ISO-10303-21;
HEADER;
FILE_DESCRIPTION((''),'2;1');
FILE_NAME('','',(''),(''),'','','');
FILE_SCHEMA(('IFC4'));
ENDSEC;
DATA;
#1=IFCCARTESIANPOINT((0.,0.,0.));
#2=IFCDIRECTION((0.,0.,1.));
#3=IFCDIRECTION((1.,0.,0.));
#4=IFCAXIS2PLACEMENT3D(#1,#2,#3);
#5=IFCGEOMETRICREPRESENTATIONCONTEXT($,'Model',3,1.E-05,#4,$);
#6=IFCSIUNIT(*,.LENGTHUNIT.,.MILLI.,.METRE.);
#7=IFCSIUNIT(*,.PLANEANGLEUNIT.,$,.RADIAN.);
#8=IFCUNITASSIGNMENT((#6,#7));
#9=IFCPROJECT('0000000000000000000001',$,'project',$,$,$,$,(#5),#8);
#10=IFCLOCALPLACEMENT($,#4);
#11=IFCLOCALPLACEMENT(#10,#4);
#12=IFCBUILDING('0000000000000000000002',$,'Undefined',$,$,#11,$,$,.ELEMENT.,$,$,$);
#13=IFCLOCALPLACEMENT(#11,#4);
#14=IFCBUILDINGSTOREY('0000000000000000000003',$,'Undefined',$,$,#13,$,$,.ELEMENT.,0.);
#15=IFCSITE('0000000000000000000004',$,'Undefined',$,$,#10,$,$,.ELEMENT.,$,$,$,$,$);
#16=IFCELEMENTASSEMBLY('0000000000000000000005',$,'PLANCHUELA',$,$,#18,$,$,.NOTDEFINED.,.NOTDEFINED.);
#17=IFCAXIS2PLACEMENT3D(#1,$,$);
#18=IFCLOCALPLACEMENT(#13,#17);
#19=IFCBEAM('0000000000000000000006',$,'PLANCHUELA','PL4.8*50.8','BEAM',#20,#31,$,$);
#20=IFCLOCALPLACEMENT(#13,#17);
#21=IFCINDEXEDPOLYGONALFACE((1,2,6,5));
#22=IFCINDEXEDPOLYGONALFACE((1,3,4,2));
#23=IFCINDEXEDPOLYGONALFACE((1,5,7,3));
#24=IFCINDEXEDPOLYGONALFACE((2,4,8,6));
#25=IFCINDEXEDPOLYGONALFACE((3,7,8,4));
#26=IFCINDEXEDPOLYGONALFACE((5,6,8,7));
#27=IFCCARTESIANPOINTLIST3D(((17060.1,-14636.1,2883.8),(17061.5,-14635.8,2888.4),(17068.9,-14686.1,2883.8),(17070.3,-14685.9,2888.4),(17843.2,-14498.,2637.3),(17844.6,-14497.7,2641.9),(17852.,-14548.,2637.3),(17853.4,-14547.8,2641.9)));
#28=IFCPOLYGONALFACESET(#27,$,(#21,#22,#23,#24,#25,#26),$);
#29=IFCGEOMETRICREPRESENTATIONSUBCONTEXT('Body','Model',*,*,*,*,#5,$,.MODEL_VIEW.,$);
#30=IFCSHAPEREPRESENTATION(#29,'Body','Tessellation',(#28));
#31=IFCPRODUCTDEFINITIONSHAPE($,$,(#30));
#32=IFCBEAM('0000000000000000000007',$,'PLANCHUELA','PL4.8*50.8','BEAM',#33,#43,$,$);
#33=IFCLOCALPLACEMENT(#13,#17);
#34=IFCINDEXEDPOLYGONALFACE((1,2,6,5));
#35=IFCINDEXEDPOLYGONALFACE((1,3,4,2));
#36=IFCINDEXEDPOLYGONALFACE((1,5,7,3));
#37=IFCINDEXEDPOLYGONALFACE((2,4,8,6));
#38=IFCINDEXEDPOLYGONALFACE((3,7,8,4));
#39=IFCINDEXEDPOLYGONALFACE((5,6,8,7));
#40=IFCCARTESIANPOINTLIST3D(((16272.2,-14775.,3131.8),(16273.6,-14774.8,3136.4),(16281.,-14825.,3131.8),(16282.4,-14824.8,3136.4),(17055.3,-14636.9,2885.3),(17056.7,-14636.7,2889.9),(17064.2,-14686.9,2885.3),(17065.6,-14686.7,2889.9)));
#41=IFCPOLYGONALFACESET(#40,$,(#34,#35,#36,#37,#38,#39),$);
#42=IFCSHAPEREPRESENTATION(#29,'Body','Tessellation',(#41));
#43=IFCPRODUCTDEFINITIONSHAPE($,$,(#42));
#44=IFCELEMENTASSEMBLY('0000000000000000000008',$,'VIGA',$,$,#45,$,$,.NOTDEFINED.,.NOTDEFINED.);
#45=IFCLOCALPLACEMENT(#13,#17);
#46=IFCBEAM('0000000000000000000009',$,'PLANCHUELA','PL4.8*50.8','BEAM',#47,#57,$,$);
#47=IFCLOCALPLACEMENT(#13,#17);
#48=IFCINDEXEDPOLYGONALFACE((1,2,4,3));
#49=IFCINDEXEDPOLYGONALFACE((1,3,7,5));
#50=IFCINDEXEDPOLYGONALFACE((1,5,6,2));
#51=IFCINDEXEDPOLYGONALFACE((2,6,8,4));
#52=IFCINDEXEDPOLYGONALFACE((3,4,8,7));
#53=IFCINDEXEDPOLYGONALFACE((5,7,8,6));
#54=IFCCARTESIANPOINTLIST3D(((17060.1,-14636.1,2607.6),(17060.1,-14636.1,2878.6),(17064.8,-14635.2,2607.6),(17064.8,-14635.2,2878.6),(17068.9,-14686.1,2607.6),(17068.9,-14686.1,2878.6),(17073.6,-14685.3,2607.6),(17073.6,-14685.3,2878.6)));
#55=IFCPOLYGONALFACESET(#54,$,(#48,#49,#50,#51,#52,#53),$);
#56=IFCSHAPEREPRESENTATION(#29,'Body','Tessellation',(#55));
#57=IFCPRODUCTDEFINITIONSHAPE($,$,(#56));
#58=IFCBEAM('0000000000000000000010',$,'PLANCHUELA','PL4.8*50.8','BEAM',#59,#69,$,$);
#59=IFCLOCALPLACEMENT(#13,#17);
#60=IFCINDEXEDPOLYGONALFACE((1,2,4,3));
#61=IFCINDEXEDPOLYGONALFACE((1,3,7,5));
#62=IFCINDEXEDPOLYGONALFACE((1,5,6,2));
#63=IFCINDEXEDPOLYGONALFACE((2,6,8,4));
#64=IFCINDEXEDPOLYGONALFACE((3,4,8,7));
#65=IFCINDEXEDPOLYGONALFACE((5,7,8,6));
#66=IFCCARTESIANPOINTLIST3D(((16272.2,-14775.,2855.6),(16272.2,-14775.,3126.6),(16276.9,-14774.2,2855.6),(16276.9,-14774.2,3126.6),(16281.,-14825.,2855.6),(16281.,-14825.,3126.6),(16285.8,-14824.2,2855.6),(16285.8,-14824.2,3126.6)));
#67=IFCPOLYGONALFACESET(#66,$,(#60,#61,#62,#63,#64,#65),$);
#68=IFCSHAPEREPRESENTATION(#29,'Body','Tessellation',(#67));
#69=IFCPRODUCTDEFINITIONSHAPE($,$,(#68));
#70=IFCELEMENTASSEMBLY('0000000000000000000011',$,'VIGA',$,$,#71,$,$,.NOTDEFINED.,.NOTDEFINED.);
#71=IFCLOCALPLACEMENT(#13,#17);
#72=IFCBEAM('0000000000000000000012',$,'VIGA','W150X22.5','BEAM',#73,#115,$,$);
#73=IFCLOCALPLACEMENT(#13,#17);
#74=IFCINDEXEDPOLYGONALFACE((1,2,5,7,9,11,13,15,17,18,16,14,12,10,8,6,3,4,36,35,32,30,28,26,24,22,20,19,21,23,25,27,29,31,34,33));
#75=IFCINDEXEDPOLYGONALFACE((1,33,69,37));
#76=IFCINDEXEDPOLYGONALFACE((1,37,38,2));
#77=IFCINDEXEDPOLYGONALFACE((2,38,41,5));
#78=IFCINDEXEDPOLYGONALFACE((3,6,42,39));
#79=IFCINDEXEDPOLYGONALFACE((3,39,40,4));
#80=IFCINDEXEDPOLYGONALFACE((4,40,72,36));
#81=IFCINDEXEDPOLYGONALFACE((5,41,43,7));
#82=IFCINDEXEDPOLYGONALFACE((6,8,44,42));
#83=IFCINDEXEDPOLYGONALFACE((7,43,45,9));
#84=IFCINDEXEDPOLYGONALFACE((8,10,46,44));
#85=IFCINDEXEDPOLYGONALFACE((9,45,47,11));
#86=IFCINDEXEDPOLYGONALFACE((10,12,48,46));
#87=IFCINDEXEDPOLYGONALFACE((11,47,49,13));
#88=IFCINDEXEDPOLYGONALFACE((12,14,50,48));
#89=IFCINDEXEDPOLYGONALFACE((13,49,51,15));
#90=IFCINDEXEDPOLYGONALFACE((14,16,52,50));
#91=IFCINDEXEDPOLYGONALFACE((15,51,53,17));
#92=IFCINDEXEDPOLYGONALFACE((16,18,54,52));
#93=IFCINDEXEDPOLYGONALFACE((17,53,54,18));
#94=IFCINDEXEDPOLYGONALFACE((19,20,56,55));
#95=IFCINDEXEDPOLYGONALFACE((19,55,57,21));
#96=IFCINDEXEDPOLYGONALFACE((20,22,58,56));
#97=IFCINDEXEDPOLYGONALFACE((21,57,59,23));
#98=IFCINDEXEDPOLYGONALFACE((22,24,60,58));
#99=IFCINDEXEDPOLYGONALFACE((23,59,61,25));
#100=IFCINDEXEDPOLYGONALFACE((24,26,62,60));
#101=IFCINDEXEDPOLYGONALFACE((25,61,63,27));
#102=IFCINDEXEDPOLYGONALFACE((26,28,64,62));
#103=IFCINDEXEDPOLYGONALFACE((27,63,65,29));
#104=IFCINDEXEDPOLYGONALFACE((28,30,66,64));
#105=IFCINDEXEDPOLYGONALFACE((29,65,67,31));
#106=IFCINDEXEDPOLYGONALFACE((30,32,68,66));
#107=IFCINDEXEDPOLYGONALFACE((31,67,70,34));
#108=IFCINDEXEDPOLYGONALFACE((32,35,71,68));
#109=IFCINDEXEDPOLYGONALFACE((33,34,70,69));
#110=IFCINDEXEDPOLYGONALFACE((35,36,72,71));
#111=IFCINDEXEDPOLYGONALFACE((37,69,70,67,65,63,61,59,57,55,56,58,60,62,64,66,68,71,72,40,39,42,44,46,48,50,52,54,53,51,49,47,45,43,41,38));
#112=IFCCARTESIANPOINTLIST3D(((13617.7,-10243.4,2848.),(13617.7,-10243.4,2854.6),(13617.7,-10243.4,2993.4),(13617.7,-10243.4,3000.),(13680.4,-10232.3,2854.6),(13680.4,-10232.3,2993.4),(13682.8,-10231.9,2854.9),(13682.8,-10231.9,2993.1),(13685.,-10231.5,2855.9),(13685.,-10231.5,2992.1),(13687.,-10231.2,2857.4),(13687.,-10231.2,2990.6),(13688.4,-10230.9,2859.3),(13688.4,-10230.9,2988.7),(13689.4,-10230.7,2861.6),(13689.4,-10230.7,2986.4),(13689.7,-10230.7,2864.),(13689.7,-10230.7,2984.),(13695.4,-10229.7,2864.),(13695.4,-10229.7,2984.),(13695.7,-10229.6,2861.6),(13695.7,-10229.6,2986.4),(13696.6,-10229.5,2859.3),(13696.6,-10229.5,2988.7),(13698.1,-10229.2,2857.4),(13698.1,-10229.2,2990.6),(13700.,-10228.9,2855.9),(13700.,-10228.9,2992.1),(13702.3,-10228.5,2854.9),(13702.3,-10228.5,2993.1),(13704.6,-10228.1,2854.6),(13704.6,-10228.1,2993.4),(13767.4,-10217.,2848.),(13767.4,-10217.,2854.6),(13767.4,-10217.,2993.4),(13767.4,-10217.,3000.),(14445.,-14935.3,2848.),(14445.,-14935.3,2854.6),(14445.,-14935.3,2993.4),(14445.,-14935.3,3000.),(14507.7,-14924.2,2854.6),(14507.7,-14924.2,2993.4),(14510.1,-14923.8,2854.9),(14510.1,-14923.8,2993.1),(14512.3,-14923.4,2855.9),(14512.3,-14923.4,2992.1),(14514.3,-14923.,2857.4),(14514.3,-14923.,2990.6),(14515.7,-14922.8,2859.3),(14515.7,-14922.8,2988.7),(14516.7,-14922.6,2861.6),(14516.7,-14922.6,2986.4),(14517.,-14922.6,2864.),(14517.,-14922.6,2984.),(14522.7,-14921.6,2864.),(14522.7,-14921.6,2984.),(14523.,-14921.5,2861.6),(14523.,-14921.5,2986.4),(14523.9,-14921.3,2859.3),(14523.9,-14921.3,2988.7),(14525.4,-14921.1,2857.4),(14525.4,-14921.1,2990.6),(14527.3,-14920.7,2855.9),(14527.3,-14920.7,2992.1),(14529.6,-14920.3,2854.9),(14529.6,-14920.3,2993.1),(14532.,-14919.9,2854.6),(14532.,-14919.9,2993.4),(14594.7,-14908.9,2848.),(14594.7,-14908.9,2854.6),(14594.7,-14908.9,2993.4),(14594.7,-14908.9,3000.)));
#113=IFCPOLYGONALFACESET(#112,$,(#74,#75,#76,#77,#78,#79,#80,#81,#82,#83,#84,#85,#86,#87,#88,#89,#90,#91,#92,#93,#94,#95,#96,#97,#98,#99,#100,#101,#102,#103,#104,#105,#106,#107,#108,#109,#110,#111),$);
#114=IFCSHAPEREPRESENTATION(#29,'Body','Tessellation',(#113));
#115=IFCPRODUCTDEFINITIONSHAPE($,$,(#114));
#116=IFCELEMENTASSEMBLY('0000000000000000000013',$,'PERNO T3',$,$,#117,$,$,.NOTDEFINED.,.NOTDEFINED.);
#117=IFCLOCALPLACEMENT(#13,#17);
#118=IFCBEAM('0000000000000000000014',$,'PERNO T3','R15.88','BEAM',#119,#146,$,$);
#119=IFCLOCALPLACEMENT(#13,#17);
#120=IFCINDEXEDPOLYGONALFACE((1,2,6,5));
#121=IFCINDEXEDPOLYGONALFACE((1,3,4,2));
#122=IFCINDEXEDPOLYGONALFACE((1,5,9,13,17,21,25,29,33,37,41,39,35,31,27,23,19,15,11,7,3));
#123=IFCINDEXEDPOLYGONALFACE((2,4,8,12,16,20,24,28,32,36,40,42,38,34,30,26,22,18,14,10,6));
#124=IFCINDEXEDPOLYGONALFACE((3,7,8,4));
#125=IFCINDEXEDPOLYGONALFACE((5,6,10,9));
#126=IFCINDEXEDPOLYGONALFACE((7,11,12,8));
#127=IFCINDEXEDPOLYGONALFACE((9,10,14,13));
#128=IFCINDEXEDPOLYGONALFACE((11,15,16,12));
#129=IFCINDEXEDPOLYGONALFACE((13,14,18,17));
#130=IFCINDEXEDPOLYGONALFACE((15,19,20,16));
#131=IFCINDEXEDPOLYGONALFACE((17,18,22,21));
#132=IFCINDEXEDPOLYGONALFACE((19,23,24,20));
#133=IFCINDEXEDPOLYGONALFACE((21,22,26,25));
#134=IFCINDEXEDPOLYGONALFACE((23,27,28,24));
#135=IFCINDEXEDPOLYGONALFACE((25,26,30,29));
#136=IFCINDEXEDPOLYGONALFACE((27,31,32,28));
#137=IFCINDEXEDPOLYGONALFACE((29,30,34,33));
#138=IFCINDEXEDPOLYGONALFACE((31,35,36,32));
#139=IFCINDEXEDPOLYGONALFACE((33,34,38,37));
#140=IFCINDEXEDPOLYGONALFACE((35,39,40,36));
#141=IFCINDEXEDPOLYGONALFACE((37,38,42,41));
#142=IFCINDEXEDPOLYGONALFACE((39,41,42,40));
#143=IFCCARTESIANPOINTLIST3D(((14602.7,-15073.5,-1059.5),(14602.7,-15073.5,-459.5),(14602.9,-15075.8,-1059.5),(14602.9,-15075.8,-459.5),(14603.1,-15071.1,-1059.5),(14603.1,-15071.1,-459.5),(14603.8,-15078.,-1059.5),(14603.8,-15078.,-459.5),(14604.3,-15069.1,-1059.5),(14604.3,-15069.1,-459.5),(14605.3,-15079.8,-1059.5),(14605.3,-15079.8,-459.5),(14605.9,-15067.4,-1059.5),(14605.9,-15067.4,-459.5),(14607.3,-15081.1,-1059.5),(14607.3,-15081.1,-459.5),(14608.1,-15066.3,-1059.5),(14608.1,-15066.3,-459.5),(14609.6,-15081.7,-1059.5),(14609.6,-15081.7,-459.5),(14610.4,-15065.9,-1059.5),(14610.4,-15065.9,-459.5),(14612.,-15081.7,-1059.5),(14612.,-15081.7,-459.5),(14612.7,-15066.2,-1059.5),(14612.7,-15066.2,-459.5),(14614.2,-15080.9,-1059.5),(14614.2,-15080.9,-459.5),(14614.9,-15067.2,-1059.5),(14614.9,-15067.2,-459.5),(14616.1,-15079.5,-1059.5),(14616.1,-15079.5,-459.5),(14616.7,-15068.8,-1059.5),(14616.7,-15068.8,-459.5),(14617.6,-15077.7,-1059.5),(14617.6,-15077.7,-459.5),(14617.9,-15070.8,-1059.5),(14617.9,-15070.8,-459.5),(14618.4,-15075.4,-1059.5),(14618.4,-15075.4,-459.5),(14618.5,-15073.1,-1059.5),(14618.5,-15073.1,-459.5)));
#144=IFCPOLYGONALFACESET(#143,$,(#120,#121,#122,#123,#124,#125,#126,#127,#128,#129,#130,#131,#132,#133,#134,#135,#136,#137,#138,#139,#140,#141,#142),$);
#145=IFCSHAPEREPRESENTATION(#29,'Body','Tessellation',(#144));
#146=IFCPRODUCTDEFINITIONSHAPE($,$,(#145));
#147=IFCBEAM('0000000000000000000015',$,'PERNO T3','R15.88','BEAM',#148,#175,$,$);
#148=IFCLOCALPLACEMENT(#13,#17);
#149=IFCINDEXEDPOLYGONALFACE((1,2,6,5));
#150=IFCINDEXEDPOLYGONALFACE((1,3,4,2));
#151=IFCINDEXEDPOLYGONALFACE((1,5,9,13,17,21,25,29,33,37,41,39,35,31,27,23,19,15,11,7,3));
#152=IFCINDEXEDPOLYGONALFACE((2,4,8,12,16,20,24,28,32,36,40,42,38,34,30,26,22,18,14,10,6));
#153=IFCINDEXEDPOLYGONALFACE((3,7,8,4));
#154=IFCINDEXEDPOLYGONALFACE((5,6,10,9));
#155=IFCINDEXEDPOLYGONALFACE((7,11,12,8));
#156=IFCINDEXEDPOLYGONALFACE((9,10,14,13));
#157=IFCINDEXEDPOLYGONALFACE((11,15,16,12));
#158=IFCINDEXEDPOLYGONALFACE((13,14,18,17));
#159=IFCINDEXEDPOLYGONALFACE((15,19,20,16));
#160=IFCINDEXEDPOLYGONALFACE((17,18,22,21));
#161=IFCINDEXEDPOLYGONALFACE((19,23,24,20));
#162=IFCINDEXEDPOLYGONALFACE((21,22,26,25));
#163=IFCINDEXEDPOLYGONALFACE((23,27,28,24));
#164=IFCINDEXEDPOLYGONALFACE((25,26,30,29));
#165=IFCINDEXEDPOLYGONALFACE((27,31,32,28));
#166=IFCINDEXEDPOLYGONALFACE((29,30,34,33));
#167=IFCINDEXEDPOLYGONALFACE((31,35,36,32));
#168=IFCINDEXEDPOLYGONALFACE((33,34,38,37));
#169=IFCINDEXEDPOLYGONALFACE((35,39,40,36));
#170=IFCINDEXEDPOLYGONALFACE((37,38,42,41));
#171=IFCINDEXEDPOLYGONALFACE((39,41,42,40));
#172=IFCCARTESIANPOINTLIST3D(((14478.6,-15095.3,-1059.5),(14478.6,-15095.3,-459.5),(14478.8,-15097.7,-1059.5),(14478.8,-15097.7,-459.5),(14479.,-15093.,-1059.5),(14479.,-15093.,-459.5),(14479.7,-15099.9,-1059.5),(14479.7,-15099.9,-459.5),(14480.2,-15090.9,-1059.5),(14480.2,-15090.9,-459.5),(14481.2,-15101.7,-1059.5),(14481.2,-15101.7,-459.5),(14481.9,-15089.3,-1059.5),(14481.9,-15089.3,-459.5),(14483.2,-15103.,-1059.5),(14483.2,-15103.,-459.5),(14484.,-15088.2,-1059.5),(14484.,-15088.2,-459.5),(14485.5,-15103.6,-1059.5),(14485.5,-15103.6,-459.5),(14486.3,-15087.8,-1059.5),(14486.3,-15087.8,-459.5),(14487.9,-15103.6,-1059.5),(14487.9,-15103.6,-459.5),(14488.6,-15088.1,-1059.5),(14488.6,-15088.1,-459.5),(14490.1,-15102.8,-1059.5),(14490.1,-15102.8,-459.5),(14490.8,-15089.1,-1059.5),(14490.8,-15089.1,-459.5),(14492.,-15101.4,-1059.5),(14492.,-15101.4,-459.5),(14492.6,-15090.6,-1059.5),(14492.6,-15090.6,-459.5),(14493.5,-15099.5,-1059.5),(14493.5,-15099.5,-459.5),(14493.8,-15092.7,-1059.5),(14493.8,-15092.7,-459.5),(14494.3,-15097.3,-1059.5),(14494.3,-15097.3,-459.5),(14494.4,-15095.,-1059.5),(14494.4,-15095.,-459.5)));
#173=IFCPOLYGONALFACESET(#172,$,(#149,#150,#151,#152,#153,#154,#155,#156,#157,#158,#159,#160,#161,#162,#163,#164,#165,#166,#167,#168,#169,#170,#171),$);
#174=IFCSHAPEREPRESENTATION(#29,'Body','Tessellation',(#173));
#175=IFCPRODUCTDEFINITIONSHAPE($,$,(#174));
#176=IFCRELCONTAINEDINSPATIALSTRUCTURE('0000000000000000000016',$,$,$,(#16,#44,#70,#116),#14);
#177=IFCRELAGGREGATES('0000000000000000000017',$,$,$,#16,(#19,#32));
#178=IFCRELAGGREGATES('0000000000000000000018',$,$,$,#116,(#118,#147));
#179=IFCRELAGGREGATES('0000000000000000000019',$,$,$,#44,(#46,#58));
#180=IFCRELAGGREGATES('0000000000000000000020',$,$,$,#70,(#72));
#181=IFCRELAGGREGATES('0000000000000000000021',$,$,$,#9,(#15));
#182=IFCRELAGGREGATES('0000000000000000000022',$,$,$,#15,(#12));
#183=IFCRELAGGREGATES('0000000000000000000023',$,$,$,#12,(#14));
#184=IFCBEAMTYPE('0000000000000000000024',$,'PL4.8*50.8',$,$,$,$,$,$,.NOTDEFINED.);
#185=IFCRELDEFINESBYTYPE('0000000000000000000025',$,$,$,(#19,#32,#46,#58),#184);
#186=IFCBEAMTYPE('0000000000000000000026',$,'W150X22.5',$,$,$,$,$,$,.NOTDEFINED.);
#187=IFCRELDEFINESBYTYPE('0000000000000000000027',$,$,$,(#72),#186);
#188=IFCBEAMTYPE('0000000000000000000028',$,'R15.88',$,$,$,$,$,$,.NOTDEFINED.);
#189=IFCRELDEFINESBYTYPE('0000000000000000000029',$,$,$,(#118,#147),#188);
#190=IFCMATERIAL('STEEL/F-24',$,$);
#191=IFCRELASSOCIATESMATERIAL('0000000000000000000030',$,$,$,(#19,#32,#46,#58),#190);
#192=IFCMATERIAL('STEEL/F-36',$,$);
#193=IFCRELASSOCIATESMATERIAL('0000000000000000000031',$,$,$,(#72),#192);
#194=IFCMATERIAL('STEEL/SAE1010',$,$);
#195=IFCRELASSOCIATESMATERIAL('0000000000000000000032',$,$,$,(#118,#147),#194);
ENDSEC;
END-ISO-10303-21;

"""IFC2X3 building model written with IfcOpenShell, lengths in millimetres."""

from ifc_helpers import new_model, si_unit, frame, origin_with_axes, origin_2d_with_axis, place, context, subcontext, project, spatial, rectangle, circle, i_section, extrude, material, type_object, element, aggregate, save


model = new_model("IFC2X3")

# Units and contexts
model_context = context("Model", 3, precision=1e-05, world=origin_with_axes())
body_context = subcontext(model_context, "Body", "Model", "MODEL_VIEW")
ifc_project = project(units=[si_unit("LENGTHUNIT", "METRE", prefix="MILLI"), si_unit("PLANEANGLEUNIT", "RADIAN")], contexts=[model_context])

# Site, building, storey
site_placement = place(None, origin_with_axes())
site = spatial("IfcSite", under=ifc_project, at=site_placement, Name="Undefined", CompositionType="ELEMENT")
building_placement = place(site_placement, origin_with_axes())
building = spatial("IfcBuilding", under=site, at=building_placement, Name="Undefined", CompositionType="ELEMENT")
storey_placement = place(building_placement, origin_with_axes())
storey = spatial("IfcBuildingStorey", under=building, at=storey_placement, Name="Undefined", CompositionType="ELEMENT", Elevation=0.0)

# Element assembly, beams
assembly_1_placement = place(storey_placement, origin_with_axes())
assembly_1 = element("IfcElementAssembly", 1, at=assembly_1_placement, inside=storey, Name="PLANCHUELA", AssemblyPlace="NOTDEFINED", PredefinedType="NOTDEFINED")
ifc_material_1 = material(Name="STEEL/F-24")
beam_type_1 = type_object("IfcBeamType", Name="PL4.8*50.8", PredefinedType="NOTDEFINED")
beam_1_placement = place(assembly_1_placement, frame((17065.2, -14661.0, 2886.1), z_axis=(-0.173653, 0.984807, 0.0), x_axis=(0.940646, 0.165865, -0.296099)))
beam_1 = element("IfcBeam", 2, at=beam_1_placement, type_object=beam_type_1, material=ifc_material_1, Name="PLANCHUELA", Description="PL4.8*50.8", ObjectType="BEAM", context=body_context, shape_type="SweptSolid", body=[
    extrude(rectangle(XDim=4.8, YDim=50.8, at=origin_2d_with_axis()), frame((832.5, 0.0, 0.0), z_axis=(-1.0, 0.0, 0.0), x_axis=(0.0, -1.0, 0.0)), (0.0, 0.0, 1.0), 832.5),
])
beam_2_placement = place(assembly_1_placement, frame((16277.3, -14799.9, 3134.1), z_axis=(-0.173653, 0.984807, 0.0), x_axis=(0.940646, 0.165865, -0.296099)))
beam_2 = element("IfcBeam", 3, at=beam_2_placement, type_object=beam_type_1, material=ifc_material_1, Name="PLANCHUELA", Description="PL4.8*50.8", ObjectType="BEAM", context=body_context, shape_type="SweptSolid", body=[
    extrude(rectangle(XDim=4.8, YDim=50.8, at=origin_2d_with_axis()), frame((832.5, 0.0, 0.0), z_axis=(-1.0, 0.0, 0.0), x_axis=(0.0, -1.0, 0.0)), (0.0, 0.0, 1.0), 832.5),
])
aggregate(assembly_1, [beam_1, beam_2])

# Element assembly, beams
assembly_2_placement = place(storey_placement, origin_with_axes())
assembly_2 = element("IfcElementAssembly", 4, at=assembly_2_placement, inside=storey, Name="VIGA", AssemblyPlace="NOTDEFINED", PredefinedType="NOTDEFINED")
beam_3_placement = place(assembly_2_placement, frame((17066.8, -14660.7, 2878.6), z_axis=(0.173651, -0.984807, 0.0), x_axis=(0.0, 0.0, -1.0)))
beam_3 = element("IfcBeam", 5, at=beam_3_placement, type_object=beam_type_1, material=ifc_material_1, Name="PLANCHUELA", Description="PL4.8*50.8", ObjectType="BEAM", context=body_context, shape_type="SweptSolid", body=[
    extrude(rectangle(XDim=4.8, YDim=50.8, at=origin_2d_with_axis()), frame((271.0, 0.0, 0.0), z_axis=(-1.0, 0.0, 0.0), x_axis=(0.0, -1.0, 0.0)), (0.0, 0.0, 1.0), 271.0),
])
beam_4_placement = place(assembly_2_placement, frame((16279.0, -14799.6, 3126.6), z_axis=(0.173651, -0.984807, 0.0), x_axis=(0.0, 0.0, -1.0)))
beam_4 = element("IfcBeam", 6, at=beam_4_placement, type_object=beam_type_1, material=ifc_material_1, Name="PLANCHUELA", Description="PL4.8*50.8", ObjectType="BEAM", context=body_context, shape_type="SweptSolid", body=[
    extrude(rectangle(XDim=4.8, YDim=50.8, at=origin_2d_with_axis()), frame((271.0, 0.0, 0.0), z_axis=(-1.0, 0.0, 0.0), x_axis=(0.0, -1.0, 0.0)), (0.0, 0.0, 1.0), 271.0),
])
ifc_material_2 = material(Name="STEEL/F-36")

# Element assembly, beam
assembly_3_placement = place(storey_placement, origin_with_axes())
assembly_3 = element("IfcElementAssembly", 7, at=assembly_3_placement, inside=storey, Name="VIGA", AssemblyPlace="NOTDEFINED", PredefinedType="NOTDEFINED")
beam_type_2 = type_object("IfcBeamType", Name="W150X22.5", PredefinedType="NOTDEFINED")
beam_5_placement = place(assembly_3_placement, frame((14519.8, -14922.1, 2924.0), z_axis=(0.0, 0.0, 1.0), x_axis=(-0.173649, 0.984808, 0.0)))
beam_5 = element("IfcBeam", 8, at=beam_5_placement, type_object=beam_type_2, material=ifc_material_2, Name="VIGA", Description="W150X22.5", ObjectType="BEAM", context=body_context, shape_type="SweptSolid", body=[
    extrude(i_section(OverallWidth=152.0, OverallDepth=152.0, WebThickness=5.8, FlangeThickness=6.6, FilletRadius=9.4, at=origin_2d_with_axis()), frame((4764.3, 0.0, 0.0), z_axis=(-1.0, 0.0, 0.0), x_axis=(0.0, -1.0, 0.0)), (0.0, 0.0, 1.0), 4764.2),
])

# Element assembly, beams
assembly_4_placement = place(storey_placement, origin_with_axes())
assembly_4 = element("IfcElementAssembly", 9, at=assembly_4_placement, inside=storey, Name="PERNO T3", AssemblyPlace="NOTDEFINED", PredefinedType="NOTDEFINED")
ifc_material_3 = material(Name="STEEL/SAE1010")
beam_type_3 = type_object("IfcBeamType", Name="R15.88", PredefinedType="NOTDEFINED")
beam_6_placement = place(assembly_4_placement, frame((14610.6, -15073.9, -459.5), z_axis=(0.984808, 0.173648, 0.000002), x_axis=(0.000002, 0.0, -1.0)))
beam_6 = element("IfcBeam", 10, at=beam_6_placement, type_object=beam_type_3, material=ifc_material_3, Name="PERNO T3", Description="R15.88", ObjectType="BEAM", context=body_context, shape_type="SweptSolid", body=[
    extrude(circle(Radius=7.9, at=origin_2d_with_axis()), frame((600.0, 0.0, 0.0), z_axis=(-1.0, 0.0, 0.0), x_axis=(0.0, -1.0, 0.0)), (0.0, 0.0, 1.0), 600.0),
])
beam_7_placement = place(assembly_4_placement, frame((14486.5, -15095.7, -459.5), z_axis=(0.984808, 0.173648, 0.000002), x_axis=(0.000002, 0.0, -1.0)))
beam_7 = element("IfcBeam", 11, at=beam_7_placement, type_object=beam_type_3, material=ifc_material_3, Name="PERNO T3", Description="R15.88", ObjectType="BEAM", context=body_context, shape_type="SweptSolid", body=[
    extrude(circle(Radius=7.9, at=origin_2d_with_axis()), frame((600.0, 0.0, 0.0), z_axis=(-1.0, 0.0, 0.0), x_axis=(0.0, -1.0, 0.0)), (0.0, 0.0, 1.0), 600.0),
])
aggregate(assembly_4, [beam_6, beam_7])

aggregate(assembly_2, [beam_3, beam_4])
aggregate(assembly_3, [beam_5])

save(model, "model.ifc")
